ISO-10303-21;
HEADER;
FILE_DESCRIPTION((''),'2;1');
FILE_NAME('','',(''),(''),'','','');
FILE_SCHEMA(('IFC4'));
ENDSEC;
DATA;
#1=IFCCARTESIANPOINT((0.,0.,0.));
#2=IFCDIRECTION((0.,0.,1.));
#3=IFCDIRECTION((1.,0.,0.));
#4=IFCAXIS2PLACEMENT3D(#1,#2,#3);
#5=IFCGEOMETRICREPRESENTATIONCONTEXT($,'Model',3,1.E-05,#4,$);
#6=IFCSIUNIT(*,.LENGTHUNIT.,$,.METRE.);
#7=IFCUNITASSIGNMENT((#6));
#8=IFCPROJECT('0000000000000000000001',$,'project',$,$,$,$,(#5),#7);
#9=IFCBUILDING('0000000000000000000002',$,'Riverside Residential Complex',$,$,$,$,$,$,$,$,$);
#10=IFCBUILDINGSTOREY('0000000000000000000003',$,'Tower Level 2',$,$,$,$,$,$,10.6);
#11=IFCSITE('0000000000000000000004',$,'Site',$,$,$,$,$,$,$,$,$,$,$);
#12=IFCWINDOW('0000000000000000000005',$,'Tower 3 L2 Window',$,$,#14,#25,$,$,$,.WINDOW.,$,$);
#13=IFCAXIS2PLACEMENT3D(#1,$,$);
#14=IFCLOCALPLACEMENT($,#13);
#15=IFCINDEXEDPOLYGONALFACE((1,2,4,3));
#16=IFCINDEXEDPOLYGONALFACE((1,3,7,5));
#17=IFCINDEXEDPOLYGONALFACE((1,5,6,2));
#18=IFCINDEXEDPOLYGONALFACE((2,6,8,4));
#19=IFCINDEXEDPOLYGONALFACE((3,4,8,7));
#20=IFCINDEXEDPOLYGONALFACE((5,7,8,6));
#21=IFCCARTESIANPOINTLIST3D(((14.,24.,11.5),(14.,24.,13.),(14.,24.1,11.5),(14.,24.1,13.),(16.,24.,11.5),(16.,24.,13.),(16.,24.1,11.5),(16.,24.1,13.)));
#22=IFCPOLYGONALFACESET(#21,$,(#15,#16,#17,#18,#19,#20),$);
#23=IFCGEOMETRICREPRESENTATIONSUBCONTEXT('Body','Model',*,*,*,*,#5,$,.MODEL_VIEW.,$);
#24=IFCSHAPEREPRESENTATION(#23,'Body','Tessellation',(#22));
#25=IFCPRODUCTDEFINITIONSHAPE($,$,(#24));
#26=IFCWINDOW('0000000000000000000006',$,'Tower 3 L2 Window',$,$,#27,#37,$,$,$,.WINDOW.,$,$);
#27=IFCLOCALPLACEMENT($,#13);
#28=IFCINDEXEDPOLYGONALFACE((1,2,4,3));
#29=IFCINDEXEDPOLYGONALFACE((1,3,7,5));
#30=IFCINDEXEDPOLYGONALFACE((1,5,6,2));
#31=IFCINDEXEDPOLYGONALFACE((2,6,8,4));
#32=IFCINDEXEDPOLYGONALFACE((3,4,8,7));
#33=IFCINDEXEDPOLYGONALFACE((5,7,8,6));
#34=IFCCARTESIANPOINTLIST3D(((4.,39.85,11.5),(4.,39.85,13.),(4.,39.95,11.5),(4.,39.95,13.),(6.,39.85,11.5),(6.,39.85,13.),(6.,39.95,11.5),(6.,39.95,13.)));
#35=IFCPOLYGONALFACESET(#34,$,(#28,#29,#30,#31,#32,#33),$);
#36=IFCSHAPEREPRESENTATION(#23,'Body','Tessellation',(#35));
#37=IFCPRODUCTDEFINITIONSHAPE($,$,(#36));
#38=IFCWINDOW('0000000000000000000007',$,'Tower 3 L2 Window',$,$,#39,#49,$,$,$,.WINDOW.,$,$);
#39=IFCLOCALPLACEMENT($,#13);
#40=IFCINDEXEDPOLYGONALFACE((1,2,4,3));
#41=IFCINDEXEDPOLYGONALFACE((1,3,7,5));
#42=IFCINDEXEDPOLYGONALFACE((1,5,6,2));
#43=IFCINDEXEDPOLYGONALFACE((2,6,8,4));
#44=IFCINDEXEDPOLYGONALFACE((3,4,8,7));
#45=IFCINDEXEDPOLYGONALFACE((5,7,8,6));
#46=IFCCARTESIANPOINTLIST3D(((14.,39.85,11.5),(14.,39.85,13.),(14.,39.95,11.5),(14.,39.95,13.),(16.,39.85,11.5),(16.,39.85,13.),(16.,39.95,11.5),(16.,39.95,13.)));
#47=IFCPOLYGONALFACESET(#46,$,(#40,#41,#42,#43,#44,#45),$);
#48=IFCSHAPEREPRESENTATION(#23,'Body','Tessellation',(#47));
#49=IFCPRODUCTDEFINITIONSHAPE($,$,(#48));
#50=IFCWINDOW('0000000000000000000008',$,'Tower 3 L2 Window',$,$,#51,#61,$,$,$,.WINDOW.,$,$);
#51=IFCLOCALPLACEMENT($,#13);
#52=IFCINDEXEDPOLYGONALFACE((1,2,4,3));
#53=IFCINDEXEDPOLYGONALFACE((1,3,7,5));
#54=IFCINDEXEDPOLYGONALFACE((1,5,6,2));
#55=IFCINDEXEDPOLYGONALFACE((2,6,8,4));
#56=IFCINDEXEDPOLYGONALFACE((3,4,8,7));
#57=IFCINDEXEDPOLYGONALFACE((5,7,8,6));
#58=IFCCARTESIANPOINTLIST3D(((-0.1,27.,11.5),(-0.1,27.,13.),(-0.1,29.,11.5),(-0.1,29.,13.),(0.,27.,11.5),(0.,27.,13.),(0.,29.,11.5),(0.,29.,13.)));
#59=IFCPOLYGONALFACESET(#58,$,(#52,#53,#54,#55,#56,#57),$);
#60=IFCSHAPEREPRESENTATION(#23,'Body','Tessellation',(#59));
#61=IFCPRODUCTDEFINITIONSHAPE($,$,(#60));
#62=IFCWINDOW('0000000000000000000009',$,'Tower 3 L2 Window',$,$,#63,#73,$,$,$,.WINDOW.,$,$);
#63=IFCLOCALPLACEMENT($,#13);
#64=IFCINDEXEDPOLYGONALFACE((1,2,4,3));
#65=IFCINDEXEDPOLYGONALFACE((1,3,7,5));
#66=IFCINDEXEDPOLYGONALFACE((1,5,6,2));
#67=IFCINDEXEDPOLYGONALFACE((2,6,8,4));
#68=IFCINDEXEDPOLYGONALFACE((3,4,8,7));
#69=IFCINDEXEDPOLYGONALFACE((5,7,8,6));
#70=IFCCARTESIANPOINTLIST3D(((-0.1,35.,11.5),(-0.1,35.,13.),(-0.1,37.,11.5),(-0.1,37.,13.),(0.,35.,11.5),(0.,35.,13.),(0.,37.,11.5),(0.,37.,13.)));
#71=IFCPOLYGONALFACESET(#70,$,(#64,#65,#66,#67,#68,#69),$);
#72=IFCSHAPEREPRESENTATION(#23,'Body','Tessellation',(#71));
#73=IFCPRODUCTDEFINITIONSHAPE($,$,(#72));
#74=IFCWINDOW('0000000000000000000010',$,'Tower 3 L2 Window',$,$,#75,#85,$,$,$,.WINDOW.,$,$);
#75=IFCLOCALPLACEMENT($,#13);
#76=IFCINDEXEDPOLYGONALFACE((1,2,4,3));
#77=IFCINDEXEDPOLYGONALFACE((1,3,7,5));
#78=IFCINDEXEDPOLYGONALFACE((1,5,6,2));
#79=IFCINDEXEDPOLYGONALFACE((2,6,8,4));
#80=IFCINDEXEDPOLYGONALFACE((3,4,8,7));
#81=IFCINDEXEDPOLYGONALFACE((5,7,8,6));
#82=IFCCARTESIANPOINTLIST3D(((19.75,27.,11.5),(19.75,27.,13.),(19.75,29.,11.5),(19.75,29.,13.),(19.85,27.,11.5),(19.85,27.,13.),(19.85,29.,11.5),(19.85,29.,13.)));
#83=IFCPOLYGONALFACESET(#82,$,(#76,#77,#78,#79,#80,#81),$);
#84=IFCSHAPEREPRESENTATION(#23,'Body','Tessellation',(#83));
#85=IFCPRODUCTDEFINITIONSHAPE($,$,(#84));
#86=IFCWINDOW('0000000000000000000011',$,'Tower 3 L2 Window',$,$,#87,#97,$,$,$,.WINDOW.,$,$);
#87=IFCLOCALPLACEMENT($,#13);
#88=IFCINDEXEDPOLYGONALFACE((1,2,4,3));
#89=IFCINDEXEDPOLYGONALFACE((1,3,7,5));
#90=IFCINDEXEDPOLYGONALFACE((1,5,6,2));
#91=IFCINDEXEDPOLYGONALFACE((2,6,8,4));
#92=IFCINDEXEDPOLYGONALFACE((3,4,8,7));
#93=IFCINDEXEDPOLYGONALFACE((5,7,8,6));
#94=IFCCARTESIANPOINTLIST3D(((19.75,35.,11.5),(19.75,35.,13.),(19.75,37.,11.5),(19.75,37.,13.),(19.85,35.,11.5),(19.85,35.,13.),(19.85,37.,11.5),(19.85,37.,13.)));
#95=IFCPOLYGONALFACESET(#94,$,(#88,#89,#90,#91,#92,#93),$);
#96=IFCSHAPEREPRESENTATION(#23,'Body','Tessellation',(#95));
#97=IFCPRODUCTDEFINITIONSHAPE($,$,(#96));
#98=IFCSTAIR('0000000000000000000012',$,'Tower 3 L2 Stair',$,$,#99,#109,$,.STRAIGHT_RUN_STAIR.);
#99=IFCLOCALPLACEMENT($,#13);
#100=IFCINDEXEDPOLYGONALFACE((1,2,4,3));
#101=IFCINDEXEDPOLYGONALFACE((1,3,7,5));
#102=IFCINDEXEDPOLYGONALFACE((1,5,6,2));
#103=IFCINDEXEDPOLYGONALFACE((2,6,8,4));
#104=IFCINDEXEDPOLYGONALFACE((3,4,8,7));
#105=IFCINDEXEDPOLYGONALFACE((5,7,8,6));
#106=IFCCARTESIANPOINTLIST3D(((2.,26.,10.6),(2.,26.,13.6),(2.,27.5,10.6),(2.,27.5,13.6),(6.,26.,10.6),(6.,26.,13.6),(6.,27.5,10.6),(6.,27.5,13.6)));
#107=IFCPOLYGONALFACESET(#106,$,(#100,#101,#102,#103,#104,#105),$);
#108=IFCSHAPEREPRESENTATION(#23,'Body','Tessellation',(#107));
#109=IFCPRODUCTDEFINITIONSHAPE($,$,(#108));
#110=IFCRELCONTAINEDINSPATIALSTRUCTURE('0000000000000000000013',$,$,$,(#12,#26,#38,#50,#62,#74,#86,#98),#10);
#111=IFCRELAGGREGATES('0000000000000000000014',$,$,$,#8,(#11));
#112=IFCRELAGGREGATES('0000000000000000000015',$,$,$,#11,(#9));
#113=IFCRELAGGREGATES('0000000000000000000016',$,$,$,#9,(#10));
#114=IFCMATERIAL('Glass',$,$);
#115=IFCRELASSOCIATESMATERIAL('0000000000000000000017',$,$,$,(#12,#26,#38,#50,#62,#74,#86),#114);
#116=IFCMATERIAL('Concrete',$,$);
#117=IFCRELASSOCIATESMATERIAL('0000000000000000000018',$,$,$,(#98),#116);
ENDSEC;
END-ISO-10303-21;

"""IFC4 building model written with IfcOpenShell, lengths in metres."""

from ifc_helpers import new_model, si_unit, frame, origin_with_axes, place, context, subcontext, project, spatial, line, indexed_curve, outline, extrude, material, element, save


model = new_model("IFC4")

# Units and contexts
model_context = context("Model", 3, precision=1e-05, world=origin_with_axes())
body_context = subcontext(model_context, "Body", "Model", "MODEL_VIEW")
ifc_project = project(units=[si_unit("LENGTHUNIT", "METRE")], contexts=[model_context])

# Site, building, storey
site = spatial("IfcSite", under=ifc_project, Name="Site")
building = spatial("IfcBuilding", under=site, Name="Riverside Residential Complex")
storey = spatial("IfcBuildingStorey", under=building, Name="Tower Level 2", Elevation=10.6)

# Shared definitions
ifc_material_1 = material(Name="Concrete")

# Windows
ifc_material_2 = material(Name="Glass")
for number, where, z_axis, x_axis, name in (
    (1, (14.0, 24.0, 11.5), (0.0, 0.0, 1.0), (1.0, 0.0, 0.0), "Tower 3 L2 Window"),
    (2, (4.0, 39.85, 11.5), (0.0, 0.0, 1.0), (1.0, 0.0, 0.0), "Tower 3 L2 Window"),
    (3, (14.0, 39.85, 11.5), (0.0, 0.0, 1.0), (1.0, 0.0, 0.0), "Tower 3 L2 Window"),
    (4, (0.0, 27.0, 11.5), (0.0, 0.0, 1.0), (0.0, 1.0, 0.0), "Tower 3 L2 Window"),
    (5, (0.0, 35.0, 11.5), (0.0, 0.0, 1.0), (0.0, 1.0, 0.0), "Tower 3 L2 Window"),
    (6, (19.85, 27.0, 11.5), (0.0, 0.0, 1.0), (0.0, 1.0, 0.0), "Tower 3 L2 Window"),
    (7, (19.85, 35.0, 11.5), (0.0, 0.0, 1.0), (0.0, 1.0, 0.0), "Tower 3 L2 Window"),
):
    element("IfcWindow", number, at=place(None, frame(where, z_axis=z_axis, x_axis=x_axis)), inside=storey, material=ifc_material_2, Name=name, PredefinedType="WINDOW", context=body_context, shape_type="SweptSolid", body=[
        extrude(outline(indexed_curve([(0.0, 0.0), (2.0, 0.0), (2.0, 0.1), (0.0, 0.1)], segments=[line(1, 2, 3, 4, 1)])), origin_with_axes(), (0.0, 0.0, 1.0), 1.5),
    ])

# Stair
stair_placement = place(None, frame((2.0, 26.0, 10.6), z_axis=(0.0, 0.0, 1.0), x_axis=(1.0, 0.0, 0.0)))
element("IfcStair", 8, at=stair_placement, inside=storey, material=ifc_material_1, Name="Tower 3 L2 Stair", PredefinedType="STRAIGHT_RUN_STAIR", context=body_context, shape_type="SweptSolid", body=[
    extrude(outline(indexed_curve([(0.0, 0.0), (4.0, 0.0), (4.0, 1.5), (0.0, 1.5)], segments=[line(1, 2, 3, 4, 1)])), origin_with_axes(), (0.0, 0.0, 1.0), 3.0),
])

save(model, "model.ifc")
